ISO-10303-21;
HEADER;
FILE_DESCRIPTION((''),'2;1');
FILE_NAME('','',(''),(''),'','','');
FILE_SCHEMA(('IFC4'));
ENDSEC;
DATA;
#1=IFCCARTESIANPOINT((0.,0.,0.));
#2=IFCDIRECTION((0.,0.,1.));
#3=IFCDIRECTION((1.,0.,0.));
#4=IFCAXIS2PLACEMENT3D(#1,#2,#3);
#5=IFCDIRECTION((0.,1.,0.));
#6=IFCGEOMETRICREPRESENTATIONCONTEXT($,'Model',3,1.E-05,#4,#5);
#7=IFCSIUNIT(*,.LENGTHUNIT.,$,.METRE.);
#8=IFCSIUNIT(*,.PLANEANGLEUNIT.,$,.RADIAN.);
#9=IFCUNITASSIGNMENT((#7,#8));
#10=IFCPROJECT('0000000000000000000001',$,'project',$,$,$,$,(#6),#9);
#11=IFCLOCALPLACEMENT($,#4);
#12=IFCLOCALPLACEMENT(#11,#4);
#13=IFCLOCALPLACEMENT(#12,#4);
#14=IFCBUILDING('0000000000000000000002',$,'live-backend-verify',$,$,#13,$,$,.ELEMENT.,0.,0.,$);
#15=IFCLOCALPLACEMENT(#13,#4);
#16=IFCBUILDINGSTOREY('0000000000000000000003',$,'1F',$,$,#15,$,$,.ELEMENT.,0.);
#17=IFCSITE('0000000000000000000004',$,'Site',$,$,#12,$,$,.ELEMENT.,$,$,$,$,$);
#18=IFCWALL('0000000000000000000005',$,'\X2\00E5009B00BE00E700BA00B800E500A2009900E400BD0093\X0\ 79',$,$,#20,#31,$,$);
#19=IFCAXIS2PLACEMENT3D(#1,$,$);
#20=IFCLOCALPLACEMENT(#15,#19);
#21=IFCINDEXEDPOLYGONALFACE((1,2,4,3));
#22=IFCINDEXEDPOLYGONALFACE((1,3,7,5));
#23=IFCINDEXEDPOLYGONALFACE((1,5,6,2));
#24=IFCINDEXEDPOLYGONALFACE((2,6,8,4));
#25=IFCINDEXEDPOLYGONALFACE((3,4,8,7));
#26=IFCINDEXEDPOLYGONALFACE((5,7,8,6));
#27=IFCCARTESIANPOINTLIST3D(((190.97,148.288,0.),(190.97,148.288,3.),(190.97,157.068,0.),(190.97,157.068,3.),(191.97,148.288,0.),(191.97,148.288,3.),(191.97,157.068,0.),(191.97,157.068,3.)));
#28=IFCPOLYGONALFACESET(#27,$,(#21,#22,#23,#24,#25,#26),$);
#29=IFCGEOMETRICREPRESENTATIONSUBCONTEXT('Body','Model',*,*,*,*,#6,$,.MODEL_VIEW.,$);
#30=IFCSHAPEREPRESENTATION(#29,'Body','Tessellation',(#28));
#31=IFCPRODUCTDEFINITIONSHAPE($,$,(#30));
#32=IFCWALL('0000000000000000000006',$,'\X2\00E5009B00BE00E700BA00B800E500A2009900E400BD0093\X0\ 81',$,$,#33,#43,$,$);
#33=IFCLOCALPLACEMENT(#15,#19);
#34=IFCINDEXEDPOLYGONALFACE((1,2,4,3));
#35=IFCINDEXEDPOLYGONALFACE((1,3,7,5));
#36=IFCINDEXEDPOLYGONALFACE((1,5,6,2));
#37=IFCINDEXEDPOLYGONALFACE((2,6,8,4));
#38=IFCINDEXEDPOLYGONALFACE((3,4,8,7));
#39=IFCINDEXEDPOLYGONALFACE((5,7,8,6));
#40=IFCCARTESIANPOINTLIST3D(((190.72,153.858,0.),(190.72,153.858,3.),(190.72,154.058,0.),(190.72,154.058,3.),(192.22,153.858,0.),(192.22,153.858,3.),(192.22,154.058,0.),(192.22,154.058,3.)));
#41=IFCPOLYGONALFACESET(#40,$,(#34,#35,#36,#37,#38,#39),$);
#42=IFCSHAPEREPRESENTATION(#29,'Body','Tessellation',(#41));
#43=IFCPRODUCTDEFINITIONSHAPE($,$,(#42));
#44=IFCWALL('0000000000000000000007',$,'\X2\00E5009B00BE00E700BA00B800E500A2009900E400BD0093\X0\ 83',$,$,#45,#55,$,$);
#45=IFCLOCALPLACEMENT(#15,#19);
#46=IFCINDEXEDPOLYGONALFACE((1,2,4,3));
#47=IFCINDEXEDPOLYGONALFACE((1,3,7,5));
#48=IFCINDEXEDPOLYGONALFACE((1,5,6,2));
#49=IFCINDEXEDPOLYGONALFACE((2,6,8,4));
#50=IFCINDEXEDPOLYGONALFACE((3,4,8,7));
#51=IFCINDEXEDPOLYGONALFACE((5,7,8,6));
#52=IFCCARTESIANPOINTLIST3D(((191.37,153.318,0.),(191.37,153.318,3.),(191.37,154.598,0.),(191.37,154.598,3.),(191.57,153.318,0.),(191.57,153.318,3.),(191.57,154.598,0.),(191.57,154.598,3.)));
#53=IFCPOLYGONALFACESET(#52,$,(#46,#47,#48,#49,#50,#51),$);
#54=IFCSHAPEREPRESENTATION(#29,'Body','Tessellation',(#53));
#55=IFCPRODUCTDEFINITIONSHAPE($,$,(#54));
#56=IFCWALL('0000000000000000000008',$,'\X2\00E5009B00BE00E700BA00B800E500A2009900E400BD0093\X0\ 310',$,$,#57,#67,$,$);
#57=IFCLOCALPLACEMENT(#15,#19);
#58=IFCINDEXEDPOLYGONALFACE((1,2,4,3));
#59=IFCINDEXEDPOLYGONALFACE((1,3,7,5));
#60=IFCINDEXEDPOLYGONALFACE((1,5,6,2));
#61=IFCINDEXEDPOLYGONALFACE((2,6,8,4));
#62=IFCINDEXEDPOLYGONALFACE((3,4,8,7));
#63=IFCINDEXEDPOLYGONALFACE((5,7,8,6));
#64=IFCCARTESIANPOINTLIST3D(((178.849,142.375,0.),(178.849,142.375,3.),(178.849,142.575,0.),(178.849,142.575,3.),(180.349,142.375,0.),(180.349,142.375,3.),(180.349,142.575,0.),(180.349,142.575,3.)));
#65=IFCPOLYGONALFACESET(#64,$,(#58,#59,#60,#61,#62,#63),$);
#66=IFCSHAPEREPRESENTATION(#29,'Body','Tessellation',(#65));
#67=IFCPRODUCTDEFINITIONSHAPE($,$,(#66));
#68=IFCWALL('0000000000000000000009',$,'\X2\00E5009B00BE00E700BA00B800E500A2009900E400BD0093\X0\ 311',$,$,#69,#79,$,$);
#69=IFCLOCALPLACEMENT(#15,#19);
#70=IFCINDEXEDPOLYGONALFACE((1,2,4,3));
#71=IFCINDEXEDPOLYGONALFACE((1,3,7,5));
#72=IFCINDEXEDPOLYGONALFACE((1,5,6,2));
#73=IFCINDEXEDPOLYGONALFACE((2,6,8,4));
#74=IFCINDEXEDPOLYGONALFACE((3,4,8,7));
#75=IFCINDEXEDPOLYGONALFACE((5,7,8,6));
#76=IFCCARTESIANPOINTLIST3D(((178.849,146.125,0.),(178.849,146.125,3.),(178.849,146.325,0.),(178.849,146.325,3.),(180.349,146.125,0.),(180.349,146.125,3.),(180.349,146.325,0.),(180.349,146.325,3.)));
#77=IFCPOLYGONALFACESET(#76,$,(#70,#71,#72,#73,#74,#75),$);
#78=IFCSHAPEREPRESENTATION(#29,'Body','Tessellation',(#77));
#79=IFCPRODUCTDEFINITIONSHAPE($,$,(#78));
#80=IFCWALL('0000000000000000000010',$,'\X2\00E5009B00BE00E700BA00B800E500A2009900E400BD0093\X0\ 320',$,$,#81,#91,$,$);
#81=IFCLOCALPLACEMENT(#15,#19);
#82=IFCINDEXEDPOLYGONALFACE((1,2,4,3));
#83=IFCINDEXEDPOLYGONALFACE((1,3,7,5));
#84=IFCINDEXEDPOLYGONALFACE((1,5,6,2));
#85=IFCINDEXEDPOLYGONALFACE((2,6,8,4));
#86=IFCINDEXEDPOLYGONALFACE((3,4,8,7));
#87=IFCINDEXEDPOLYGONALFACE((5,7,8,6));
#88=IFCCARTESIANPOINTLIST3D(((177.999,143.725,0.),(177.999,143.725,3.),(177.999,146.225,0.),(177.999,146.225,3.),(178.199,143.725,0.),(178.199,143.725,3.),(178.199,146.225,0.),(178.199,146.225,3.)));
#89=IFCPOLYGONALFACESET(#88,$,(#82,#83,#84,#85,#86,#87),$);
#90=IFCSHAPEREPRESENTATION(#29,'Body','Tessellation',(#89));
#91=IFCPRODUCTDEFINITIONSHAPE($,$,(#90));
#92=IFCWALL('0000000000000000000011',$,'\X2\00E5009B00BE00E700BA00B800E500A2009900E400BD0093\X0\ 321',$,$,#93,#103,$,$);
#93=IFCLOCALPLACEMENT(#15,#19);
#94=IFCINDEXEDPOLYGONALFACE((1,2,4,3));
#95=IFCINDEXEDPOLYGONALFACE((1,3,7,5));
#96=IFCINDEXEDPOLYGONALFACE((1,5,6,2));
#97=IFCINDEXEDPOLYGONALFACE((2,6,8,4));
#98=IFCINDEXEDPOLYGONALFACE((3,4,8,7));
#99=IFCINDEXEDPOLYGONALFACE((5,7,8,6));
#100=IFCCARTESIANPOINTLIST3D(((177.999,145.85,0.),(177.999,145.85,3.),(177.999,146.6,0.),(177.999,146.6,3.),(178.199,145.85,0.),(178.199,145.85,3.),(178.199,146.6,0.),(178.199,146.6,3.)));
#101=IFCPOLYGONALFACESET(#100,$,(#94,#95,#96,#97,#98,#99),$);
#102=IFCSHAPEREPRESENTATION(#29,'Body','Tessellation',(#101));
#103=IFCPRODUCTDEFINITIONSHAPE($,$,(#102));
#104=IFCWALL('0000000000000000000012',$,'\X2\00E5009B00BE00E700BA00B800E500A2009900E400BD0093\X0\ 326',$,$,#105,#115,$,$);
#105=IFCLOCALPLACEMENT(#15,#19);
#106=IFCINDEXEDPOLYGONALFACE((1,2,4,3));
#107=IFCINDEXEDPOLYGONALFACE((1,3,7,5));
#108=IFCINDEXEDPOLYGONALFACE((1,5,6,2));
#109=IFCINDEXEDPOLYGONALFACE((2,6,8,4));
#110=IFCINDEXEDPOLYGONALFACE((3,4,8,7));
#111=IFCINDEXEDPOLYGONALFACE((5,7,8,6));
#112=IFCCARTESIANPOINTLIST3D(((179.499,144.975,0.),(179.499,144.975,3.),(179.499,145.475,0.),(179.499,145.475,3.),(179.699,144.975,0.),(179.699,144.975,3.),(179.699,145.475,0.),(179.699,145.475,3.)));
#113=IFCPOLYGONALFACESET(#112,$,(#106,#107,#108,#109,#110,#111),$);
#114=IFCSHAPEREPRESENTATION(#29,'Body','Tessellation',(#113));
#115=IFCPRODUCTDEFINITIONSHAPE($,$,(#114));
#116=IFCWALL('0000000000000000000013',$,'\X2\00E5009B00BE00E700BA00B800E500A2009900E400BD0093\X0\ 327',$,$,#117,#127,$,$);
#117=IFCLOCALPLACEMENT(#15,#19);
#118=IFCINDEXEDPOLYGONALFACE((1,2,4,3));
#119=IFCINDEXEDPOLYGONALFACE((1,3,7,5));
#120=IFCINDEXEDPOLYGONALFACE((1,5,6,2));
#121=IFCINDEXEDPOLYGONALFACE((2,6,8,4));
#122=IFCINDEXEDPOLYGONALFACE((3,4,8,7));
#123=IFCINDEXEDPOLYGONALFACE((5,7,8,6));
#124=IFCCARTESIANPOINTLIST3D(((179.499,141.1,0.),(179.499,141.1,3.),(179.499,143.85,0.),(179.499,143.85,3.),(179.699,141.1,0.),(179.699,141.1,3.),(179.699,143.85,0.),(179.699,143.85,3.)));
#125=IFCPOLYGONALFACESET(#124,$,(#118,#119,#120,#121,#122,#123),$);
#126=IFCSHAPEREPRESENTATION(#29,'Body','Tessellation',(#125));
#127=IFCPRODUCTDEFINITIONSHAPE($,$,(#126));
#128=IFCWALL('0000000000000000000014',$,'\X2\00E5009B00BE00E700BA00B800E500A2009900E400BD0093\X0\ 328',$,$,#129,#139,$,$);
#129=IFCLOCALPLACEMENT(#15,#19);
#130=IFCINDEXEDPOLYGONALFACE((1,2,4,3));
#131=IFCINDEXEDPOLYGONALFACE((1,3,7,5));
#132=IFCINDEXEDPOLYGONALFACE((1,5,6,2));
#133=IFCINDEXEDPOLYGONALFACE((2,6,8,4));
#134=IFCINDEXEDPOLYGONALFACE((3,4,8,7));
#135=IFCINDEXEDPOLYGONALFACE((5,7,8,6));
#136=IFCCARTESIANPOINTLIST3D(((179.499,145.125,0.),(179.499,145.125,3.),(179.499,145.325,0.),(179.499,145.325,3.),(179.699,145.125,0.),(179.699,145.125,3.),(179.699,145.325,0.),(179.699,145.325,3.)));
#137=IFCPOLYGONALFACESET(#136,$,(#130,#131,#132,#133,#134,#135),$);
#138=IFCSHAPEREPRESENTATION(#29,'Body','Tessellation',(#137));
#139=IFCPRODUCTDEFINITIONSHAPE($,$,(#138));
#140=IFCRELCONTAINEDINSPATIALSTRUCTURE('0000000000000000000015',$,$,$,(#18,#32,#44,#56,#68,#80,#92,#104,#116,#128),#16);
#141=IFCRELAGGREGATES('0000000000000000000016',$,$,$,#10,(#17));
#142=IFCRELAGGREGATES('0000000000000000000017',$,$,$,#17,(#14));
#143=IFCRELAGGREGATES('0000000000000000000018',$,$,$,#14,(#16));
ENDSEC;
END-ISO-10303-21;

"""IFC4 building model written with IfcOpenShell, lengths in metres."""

from ifc_helpers import new_model, si_unit, direction, frame, frame_2d, origin_with_axes, place, context, subcontext, project, spatial, rectangle, extrude, element, save


model = new_model("IFC4")

# Units and contexts
model_context = context("Model", 3, precision=1e-05, world=origin_with_axes(), true_north=direction((0.0, 1.0, 0.0)))
body_context = subcontext(model_context, "Body", "Model", "MODEL_VIEW")
ifc_project = project(units=[si_unit("LENGTHUNIT", "METRE"), si_unit("PLANEANGLEUNIT", "RADIAN")], contexts=[model_context])

# Site, building, storey
placement = place(None, origin_with_axes())
site_placement = place(placement, origin_with_axes())
site = spatial("IfcSite", under=ifc_project, at=site_placement, Name="Site", CompositionType="ELEMENT")
building_placement = place(site_placement, origin_with_axes())
building = spatial("IfcBuilding", under=site, at=building_placement, Name="live-backend-verify", CompositionType="ELEMENT", ElevationOfRefHeight=0.0, ElevationOfTerrain=0.0)
storey_placement = place(building_placement, origin_with_axes())
storey = spatial("IfcBuildingStorey", under=building, at=storey_placement, Name="1F", CompositionType="ELEMENT", Elevation=0.0)

# Walls
wall_1_placement = place(storey_placement, frame((191.47, 152.678, 0.0), z_axis=(0.0, 0.0, 1.0), x_axis=(1.0, 0.0, 0.0)))
element("IfcWall", 1, at=wall_1_placement, inside=storey, Name="å\u009b¾çº¸å¢\u0099ä½\u0093 79", context=body_context, shape_type="SweptSolid", body=[
    extrude(rectangle(XDim=1.0, YDim=8.78, at=frame_2d((0.0, 0.0), x_axis=(1.0, 0.0, 0.0))), frame((0.0, 0.0, 0.0), z_axis=(0.0, 0.0, 1.0)), (0.0, 0.0, 1.0), 3.0),
])
wall_2_placement = place(storey_placement, frame((191.47, 153.958, 0.0), z_axis=(0.0, 0.0, 1.0), x_axis=(1.0, 0.0, 0.0)))
element("IfcWall", 2, at=wall_2_placement, inside=storey, Name="å\u009b¾çº¸å¢\u0099ä½\u0093 81", context=body_context, shape_type="SweptSolid", body=[
    extrude(rectangle(XDim=1.5, YDim=0.2, at=frame_2d((0.0, 0.0), x_axis=(1.0, 0.0, 0.0))), frame((0.0, 0.0, 0.0), z_axis=(0.0, 0.0, 1.0)), (0.0, 0.0, 1.0), 3.0),
])
wall_3_placement = place(storey_placement, frame((191.47, 153.958, 0.0), z_axis=(0.0, 0.0, 1.0), x_axis=(0.0, -1.0, 0.0)))
element("IfcWall", 3, at=wall_3_placement, inside=storey, Name="å\u009b¾çº¸å¢\u0099ä½\u0093 83", context=body_context, shape_type="SweptSolid", body=[
    extrude(rectangle(XDim=1.28, YDim=0.2, at=frame_2d((0.0, 0.0), x_axis=(1.0, 0.0, 0.0))), frame((0.0, 0.0, 0.0), z_axis=(0.0, 0.0, 1.0)), (0.0, 0.0, 1.0), 3.0),
])
for number, where, z_axis, x_axis, name in (
    (4, (179.599, 142.475, 0.0), (0.0, 0.0, 1.0), (-1.0, 0.0, 0.0), "å\u009b¾çº¸å¢\u0099ä½\u0093 310"),
    (5, (179.599, 146.225, 0.0), (0.0, 0.0, 1.0), (-1.0, 0.0, 0.0), "å\u009b¾çº¸å¢\u0099ä½\u0093 311"),
):
    element("IfcWall", number, at=place(storey_placement, frame(where, z_axis=z_axis, x_axis=x_axis)), inside=storey, Name=name, context=body_context, shape_type="SweptSolid", body=[
        extrude(rectangle(XDim=1.5, YDim=0.2, at=frame_2d((0.0, 0.0), x_axis=(1.0, 0.0, 0.0))), frame((0.0, 0.0, 0.0), z_axis=(0.0, 0.0, 1.0)), (0.0, 0.0, 1.0), 3.0),
    ])
wall_4_placement = place(storey_placement, frame((178.099, 144.975, 0.0), z_axis=(0.0, 0.0, 1.0), x_axis=(0.0, -1.0, 0.0)))
element("IfcWall", 6, at=wall_4_placement, inside=storey, Name="å\u009b¾çº¸å¢\u0099ä½\u0093 320", context=body_context, shape_type="SweptSolid", body=[
    extrude(rectangle(XDim=2.5, YDim=0.2, at=frame_2d((0.0, 0.0), x_axis=(1.0, 0.0, 0.0))), frame((0.0, 0.0, 0.0), z_axis=(0.0, 0.0, 1.0)), (0.0, 0.0, 1.0), 3.0),
])
wall_5_placement = place(storey_placement, frame((178.099, 146.225, 0.0), z_axis=(0.0, 0.0, 1.0), x_axis=(0.0, -1.0, 0.0)))
element("IfcWall", 7, at=wall_5_placement, inside=storey, Name="å\u009b¾çº¸å¢\u0099ä½\u0093 321", context=body_context, shape_type="SweptSolid", body=[
    extrude(rectangle(XDim=0.75, YDim=0.2, at=frame_2d((0.0, 0.0), x_axis=(1.0, 0.0, 0.0))), frame((0.0, 0.0, 0.0), z_axis=(0.0, 0.0, 1.0)), (0.0, 0.0, 1.0), 3.0),
])
wall_6_placement = place(storey_placement, frame((179.599, 145.225, 0.0), z_axis=(0.0, 0.0, 1.0), x_axis=(0.0, 1.0, 0.0)))
element("IfcWall", 8, at=wall_6_placement, inside=storey, Name="å\u009b¾çº¸å¢\u0099ä½\u0093 326", context=body_context, shape_type="SweptSolid", body=[
    extrude(rectangle(XDim=0.5, YDim=0.2, at=frame_2d((0.0, 0.0), x_axis=(1.0, 0.0, 0.0))), frame((0.0, 0.0, 0.0), z_axis=(0.0, 0.0, 1.0)), (0.0, 0.0, 1.0), 3.0),
])
wall_7_placement = place(storey_placement, frame((179.599, 142.475, 0.0), z_axis=(0.0, 0.0, 1.0), x_axis=(0.0, 1.0, 0.0)))
element("IfcWall", 9, at=wall_7_placement, inside=storey, Name="å\u009b¾çº¸å¢\u0099ä½\u0093 327", context=body_context, shape_type="SweptSolid", body=[
    extrude(rectangle(XDim=2.75, YDim=0.2, at=frame_2d((0.0, 0.0), x_axis=(1.0, 0.0, 0.0))), frame((0.0, 0.0, 0.0), z_axis=(0.0, 0.0, 1.0)), (0.0, 0.0, 1.0), 3.0),
])
wall_8_placement = place(storey_placement, frame((179.599, 145.225, 0.0), z_axis=(0.0, 0.0, 1.0), x_axis=(1.0, 0.0, 0.0)))
element("IfcWall", 10, at=wall_8_placement, inside=storey, Name="å\u009b¾çº¸å¢\u0099ä½\u0093 328", context=body_context, shape_type="SweptSolid", body=[
    extrude(rectangle(XDim=0.2, YDim=0.2, at=frame_2d((0.0, 0.0), x_axis=(1.0, 0.0, 0.0))), frame((0.0, 0.0, 0.0), z_axis=(0.0, 0.0, 1.0)), (0.0, 0.0, 1.0), 3.0),
])

save(model, "model.ifc")
